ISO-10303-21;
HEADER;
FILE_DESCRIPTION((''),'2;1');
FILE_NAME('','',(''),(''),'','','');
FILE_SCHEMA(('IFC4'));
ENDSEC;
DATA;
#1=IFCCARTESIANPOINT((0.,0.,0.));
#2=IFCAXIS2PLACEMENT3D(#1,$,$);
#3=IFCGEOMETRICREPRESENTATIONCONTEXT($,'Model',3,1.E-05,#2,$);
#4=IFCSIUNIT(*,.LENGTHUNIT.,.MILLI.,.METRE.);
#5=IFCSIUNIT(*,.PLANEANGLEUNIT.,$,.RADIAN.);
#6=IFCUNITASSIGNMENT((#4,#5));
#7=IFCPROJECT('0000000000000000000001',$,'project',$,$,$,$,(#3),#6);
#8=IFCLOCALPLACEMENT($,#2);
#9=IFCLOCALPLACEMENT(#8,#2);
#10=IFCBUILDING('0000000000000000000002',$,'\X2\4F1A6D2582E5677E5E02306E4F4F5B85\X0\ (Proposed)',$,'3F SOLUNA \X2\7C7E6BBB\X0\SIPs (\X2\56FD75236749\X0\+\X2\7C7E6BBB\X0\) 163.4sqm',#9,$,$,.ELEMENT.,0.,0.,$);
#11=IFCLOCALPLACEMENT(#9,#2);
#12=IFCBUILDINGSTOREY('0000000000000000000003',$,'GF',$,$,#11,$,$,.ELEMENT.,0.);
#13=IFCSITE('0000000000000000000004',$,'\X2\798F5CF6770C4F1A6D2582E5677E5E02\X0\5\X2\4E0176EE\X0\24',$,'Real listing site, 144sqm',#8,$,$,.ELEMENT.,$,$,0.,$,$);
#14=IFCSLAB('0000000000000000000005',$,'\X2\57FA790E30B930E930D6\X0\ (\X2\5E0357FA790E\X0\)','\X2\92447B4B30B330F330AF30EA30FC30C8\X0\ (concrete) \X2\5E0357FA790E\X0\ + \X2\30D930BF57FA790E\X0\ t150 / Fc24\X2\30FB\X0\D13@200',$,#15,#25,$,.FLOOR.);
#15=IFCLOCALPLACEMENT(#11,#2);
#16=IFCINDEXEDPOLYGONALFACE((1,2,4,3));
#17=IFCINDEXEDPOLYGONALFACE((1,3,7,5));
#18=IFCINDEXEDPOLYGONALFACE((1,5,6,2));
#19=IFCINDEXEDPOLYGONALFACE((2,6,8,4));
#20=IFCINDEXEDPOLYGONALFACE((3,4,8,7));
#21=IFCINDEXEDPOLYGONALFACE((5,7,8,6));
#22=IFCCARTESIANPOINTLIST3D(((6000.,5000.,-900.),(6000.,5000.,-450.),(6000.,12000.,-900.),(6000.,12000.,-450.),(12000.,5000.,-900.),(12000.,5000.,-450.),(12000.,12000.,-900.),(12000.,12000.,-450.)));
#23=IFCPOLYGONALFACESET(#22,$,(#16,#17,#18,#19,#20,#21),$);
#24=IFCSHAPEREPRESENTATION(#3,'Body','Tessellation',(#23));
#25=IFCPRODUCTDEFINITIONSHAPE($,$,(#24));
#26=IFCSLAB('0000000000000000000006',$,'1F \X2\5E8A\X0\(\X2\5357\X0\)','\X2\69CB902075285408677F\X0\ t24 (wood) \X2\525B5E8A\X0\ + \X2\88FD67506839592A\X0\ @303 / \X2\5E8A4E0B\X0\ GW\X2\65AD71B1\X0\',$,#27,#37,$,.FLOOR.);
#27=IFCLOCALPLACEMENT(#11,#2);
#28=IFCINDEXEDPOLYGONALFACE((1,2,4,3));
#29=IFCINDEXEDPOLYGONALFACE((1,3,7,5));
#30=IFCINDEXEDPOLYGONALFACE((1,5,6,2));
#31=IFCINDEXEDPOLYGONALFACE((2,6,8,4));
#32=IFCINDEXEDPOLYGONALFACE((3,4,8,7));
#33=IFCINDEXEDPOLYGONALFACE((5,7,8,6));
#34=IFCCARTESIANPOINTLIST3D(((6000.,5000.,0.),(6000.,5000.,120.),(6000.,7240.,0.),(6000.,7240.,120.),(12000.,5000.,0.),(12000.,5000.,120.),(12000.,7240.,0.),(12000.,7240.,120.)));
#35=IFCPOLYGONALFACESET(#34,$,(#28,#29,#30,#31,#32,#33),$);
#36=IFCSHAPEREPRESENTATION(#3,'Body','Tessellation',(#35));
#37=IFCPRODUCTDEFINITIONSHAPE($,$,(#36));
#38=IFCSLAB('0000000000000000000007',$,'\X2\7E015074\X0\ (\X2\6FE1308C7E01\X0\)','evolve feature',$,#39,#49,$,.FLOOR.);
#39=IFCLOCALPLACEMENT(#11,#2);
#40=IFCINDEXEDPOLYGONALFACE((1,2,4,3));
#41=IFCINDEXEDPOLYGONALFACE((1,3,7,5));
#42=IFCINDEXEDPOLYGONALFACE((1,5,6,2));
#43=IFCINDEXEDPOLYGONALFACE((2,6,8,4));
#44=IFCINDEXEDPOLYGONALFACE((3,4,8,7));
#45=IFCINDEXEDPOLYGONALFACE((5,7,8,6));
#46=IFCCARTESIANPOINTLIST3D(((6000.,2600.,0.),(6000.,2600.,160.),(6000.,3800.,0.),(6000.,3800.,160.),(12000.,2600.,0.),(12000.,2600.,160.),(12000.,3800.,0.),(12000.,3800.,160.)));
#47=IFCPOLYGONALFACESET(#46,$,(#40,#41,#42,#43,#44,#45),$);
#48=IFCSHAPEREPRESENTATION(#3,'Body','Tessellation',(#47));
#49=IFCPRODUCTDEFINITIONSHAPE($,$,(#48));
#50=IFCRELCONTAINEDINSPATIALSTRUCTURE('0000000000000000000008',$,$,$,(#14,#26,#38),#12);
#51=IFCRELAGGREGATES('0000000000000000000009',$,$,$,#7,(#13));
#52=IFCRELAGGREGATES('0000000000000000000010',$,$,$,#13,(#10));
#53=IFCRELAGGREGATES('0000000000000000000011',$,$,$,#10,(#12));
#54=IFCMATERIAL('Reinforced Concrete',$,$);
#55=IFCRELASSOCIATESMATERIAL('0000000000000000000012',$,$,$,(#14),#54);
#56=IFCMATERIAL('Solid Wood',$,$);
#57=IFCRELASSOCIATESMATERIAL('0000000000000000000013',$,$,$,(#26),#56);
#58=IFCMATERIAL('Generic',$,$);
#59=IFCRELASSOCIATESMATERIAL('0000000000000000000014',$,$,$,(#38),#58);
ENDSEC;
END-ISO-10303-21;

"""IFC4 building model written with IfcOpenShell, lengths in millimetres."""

from ifc_helpers import new_model, si_unit, frame, frame_2d, origin, place, context, project, spatial, rectangle, extrude, material, element, save


model = new_model("IFC4")

# Units and contexts
model_context = context("Model", 3, precision=1e-05, world=origin())
ifc_project = project(units=[si_unit("LENGTHUNIT", "METRE", prefix="MILLI"), si_unit("PLANEANGLEUNIT", "RADIAN")], contexts=[model_context])

# Site, building, storey
site_placement = place(None, origin())
site = spatial("IfcSite", under=ifc_project, at=site_placement, Name="福島県会津若松市5丁目24", ObjectType="Real listing site, 144sqm", CompositionType="ELEMENT", RefElevation=0.0)
building_placement = place(site_placement, origin())
building = spatial("IfcBuilding", under=site, at=building_placement, Name="会津若松市の住宅 (Proposed)", ObjectType="3F SOLUNA 籾殻SIPs (国産杉+籾殻) 163.4sqm", CompositionType="ELEMENT", ElevationOfRefHeight=0.0, ElevationOfTerrain=0.0)
storey_placement = place(building_placement, origin())
storey = spatial("IfcBuildingStorey", under=building, at=storey_placement, Name="GF", CompositionType="ELEMENT", Elevation=0.0)

# Slabs
ifc_material_1 = material(Name="Reinforced Concrete")
slab_1_placement = place(storey_placement, frame((3000.0, 2500.0, -450.0)))
element("IfcSlab", 1, at=slab_1_placement, inside=storey, material=ifc_material_1, Name="基礎スラブ (布基礎)", Description="鉄筋コンクリート (concrete) 布基礎 + ベタ基礎 t150 / Fc24・D13@200", PredefinedType="FLOOR", context=model_context, shape_type="SweptSolid", body=[
    extrude(rectangle(XDim=6000.0, YDim=7000.0, at=frame_2d((3000.0, 3500.0))), frame((3000.0, 2500.0, -450.0)), (0.0, 0.0, 1.0), 450.0),
])
ifc_material_2 = material(Name="Solid Wood")
slab_2_placement = place(storey_placement, frame((3000.0, 2500.0, 0.0)))
element("IfcSlab", 2, at=slab_2_placement, inside=storey, material=ifc_material_2, Name="1F 床(南)", Description="構造用合板 t24 (wood) 剛床 + 製材根太 @303 / 床下 GW断熱", PredefinedType="FLOOR", context=model_context, shape_type="SweptSolid", body=[
    extrude(rectangle(XDim=6000.0, YDim=2240.0, at=frame_2d((3000.0, 1120.0))), frame((3000.0, 2500.0, 0.0)), (0.0, 0.0, 1.0), 120.0),
])
ifc_material_3 = material(Name="Generic")
slab_3_placement = place(storey_placement, frame((3000.0, 1300.0, 0.0)))
element("IfcSlab", 3, at=slab_3_placement, inside=storey, material=ifc_material_3, Name="縁側 (濡れ縁)", Description="evolve feature", PredefinedType="FLOOR", context=model_context, shape_type="SweptSolid", body=[
    extrude(rectangle(XDim=6000.0, YDim=1200.0, at=frame_2d((3000.0, 600.0))), frame((3000.0, 1300.0, 0.0)), (0.0, 0.0, 1.0), 160.0),
])

save(model, "model.ifc")
